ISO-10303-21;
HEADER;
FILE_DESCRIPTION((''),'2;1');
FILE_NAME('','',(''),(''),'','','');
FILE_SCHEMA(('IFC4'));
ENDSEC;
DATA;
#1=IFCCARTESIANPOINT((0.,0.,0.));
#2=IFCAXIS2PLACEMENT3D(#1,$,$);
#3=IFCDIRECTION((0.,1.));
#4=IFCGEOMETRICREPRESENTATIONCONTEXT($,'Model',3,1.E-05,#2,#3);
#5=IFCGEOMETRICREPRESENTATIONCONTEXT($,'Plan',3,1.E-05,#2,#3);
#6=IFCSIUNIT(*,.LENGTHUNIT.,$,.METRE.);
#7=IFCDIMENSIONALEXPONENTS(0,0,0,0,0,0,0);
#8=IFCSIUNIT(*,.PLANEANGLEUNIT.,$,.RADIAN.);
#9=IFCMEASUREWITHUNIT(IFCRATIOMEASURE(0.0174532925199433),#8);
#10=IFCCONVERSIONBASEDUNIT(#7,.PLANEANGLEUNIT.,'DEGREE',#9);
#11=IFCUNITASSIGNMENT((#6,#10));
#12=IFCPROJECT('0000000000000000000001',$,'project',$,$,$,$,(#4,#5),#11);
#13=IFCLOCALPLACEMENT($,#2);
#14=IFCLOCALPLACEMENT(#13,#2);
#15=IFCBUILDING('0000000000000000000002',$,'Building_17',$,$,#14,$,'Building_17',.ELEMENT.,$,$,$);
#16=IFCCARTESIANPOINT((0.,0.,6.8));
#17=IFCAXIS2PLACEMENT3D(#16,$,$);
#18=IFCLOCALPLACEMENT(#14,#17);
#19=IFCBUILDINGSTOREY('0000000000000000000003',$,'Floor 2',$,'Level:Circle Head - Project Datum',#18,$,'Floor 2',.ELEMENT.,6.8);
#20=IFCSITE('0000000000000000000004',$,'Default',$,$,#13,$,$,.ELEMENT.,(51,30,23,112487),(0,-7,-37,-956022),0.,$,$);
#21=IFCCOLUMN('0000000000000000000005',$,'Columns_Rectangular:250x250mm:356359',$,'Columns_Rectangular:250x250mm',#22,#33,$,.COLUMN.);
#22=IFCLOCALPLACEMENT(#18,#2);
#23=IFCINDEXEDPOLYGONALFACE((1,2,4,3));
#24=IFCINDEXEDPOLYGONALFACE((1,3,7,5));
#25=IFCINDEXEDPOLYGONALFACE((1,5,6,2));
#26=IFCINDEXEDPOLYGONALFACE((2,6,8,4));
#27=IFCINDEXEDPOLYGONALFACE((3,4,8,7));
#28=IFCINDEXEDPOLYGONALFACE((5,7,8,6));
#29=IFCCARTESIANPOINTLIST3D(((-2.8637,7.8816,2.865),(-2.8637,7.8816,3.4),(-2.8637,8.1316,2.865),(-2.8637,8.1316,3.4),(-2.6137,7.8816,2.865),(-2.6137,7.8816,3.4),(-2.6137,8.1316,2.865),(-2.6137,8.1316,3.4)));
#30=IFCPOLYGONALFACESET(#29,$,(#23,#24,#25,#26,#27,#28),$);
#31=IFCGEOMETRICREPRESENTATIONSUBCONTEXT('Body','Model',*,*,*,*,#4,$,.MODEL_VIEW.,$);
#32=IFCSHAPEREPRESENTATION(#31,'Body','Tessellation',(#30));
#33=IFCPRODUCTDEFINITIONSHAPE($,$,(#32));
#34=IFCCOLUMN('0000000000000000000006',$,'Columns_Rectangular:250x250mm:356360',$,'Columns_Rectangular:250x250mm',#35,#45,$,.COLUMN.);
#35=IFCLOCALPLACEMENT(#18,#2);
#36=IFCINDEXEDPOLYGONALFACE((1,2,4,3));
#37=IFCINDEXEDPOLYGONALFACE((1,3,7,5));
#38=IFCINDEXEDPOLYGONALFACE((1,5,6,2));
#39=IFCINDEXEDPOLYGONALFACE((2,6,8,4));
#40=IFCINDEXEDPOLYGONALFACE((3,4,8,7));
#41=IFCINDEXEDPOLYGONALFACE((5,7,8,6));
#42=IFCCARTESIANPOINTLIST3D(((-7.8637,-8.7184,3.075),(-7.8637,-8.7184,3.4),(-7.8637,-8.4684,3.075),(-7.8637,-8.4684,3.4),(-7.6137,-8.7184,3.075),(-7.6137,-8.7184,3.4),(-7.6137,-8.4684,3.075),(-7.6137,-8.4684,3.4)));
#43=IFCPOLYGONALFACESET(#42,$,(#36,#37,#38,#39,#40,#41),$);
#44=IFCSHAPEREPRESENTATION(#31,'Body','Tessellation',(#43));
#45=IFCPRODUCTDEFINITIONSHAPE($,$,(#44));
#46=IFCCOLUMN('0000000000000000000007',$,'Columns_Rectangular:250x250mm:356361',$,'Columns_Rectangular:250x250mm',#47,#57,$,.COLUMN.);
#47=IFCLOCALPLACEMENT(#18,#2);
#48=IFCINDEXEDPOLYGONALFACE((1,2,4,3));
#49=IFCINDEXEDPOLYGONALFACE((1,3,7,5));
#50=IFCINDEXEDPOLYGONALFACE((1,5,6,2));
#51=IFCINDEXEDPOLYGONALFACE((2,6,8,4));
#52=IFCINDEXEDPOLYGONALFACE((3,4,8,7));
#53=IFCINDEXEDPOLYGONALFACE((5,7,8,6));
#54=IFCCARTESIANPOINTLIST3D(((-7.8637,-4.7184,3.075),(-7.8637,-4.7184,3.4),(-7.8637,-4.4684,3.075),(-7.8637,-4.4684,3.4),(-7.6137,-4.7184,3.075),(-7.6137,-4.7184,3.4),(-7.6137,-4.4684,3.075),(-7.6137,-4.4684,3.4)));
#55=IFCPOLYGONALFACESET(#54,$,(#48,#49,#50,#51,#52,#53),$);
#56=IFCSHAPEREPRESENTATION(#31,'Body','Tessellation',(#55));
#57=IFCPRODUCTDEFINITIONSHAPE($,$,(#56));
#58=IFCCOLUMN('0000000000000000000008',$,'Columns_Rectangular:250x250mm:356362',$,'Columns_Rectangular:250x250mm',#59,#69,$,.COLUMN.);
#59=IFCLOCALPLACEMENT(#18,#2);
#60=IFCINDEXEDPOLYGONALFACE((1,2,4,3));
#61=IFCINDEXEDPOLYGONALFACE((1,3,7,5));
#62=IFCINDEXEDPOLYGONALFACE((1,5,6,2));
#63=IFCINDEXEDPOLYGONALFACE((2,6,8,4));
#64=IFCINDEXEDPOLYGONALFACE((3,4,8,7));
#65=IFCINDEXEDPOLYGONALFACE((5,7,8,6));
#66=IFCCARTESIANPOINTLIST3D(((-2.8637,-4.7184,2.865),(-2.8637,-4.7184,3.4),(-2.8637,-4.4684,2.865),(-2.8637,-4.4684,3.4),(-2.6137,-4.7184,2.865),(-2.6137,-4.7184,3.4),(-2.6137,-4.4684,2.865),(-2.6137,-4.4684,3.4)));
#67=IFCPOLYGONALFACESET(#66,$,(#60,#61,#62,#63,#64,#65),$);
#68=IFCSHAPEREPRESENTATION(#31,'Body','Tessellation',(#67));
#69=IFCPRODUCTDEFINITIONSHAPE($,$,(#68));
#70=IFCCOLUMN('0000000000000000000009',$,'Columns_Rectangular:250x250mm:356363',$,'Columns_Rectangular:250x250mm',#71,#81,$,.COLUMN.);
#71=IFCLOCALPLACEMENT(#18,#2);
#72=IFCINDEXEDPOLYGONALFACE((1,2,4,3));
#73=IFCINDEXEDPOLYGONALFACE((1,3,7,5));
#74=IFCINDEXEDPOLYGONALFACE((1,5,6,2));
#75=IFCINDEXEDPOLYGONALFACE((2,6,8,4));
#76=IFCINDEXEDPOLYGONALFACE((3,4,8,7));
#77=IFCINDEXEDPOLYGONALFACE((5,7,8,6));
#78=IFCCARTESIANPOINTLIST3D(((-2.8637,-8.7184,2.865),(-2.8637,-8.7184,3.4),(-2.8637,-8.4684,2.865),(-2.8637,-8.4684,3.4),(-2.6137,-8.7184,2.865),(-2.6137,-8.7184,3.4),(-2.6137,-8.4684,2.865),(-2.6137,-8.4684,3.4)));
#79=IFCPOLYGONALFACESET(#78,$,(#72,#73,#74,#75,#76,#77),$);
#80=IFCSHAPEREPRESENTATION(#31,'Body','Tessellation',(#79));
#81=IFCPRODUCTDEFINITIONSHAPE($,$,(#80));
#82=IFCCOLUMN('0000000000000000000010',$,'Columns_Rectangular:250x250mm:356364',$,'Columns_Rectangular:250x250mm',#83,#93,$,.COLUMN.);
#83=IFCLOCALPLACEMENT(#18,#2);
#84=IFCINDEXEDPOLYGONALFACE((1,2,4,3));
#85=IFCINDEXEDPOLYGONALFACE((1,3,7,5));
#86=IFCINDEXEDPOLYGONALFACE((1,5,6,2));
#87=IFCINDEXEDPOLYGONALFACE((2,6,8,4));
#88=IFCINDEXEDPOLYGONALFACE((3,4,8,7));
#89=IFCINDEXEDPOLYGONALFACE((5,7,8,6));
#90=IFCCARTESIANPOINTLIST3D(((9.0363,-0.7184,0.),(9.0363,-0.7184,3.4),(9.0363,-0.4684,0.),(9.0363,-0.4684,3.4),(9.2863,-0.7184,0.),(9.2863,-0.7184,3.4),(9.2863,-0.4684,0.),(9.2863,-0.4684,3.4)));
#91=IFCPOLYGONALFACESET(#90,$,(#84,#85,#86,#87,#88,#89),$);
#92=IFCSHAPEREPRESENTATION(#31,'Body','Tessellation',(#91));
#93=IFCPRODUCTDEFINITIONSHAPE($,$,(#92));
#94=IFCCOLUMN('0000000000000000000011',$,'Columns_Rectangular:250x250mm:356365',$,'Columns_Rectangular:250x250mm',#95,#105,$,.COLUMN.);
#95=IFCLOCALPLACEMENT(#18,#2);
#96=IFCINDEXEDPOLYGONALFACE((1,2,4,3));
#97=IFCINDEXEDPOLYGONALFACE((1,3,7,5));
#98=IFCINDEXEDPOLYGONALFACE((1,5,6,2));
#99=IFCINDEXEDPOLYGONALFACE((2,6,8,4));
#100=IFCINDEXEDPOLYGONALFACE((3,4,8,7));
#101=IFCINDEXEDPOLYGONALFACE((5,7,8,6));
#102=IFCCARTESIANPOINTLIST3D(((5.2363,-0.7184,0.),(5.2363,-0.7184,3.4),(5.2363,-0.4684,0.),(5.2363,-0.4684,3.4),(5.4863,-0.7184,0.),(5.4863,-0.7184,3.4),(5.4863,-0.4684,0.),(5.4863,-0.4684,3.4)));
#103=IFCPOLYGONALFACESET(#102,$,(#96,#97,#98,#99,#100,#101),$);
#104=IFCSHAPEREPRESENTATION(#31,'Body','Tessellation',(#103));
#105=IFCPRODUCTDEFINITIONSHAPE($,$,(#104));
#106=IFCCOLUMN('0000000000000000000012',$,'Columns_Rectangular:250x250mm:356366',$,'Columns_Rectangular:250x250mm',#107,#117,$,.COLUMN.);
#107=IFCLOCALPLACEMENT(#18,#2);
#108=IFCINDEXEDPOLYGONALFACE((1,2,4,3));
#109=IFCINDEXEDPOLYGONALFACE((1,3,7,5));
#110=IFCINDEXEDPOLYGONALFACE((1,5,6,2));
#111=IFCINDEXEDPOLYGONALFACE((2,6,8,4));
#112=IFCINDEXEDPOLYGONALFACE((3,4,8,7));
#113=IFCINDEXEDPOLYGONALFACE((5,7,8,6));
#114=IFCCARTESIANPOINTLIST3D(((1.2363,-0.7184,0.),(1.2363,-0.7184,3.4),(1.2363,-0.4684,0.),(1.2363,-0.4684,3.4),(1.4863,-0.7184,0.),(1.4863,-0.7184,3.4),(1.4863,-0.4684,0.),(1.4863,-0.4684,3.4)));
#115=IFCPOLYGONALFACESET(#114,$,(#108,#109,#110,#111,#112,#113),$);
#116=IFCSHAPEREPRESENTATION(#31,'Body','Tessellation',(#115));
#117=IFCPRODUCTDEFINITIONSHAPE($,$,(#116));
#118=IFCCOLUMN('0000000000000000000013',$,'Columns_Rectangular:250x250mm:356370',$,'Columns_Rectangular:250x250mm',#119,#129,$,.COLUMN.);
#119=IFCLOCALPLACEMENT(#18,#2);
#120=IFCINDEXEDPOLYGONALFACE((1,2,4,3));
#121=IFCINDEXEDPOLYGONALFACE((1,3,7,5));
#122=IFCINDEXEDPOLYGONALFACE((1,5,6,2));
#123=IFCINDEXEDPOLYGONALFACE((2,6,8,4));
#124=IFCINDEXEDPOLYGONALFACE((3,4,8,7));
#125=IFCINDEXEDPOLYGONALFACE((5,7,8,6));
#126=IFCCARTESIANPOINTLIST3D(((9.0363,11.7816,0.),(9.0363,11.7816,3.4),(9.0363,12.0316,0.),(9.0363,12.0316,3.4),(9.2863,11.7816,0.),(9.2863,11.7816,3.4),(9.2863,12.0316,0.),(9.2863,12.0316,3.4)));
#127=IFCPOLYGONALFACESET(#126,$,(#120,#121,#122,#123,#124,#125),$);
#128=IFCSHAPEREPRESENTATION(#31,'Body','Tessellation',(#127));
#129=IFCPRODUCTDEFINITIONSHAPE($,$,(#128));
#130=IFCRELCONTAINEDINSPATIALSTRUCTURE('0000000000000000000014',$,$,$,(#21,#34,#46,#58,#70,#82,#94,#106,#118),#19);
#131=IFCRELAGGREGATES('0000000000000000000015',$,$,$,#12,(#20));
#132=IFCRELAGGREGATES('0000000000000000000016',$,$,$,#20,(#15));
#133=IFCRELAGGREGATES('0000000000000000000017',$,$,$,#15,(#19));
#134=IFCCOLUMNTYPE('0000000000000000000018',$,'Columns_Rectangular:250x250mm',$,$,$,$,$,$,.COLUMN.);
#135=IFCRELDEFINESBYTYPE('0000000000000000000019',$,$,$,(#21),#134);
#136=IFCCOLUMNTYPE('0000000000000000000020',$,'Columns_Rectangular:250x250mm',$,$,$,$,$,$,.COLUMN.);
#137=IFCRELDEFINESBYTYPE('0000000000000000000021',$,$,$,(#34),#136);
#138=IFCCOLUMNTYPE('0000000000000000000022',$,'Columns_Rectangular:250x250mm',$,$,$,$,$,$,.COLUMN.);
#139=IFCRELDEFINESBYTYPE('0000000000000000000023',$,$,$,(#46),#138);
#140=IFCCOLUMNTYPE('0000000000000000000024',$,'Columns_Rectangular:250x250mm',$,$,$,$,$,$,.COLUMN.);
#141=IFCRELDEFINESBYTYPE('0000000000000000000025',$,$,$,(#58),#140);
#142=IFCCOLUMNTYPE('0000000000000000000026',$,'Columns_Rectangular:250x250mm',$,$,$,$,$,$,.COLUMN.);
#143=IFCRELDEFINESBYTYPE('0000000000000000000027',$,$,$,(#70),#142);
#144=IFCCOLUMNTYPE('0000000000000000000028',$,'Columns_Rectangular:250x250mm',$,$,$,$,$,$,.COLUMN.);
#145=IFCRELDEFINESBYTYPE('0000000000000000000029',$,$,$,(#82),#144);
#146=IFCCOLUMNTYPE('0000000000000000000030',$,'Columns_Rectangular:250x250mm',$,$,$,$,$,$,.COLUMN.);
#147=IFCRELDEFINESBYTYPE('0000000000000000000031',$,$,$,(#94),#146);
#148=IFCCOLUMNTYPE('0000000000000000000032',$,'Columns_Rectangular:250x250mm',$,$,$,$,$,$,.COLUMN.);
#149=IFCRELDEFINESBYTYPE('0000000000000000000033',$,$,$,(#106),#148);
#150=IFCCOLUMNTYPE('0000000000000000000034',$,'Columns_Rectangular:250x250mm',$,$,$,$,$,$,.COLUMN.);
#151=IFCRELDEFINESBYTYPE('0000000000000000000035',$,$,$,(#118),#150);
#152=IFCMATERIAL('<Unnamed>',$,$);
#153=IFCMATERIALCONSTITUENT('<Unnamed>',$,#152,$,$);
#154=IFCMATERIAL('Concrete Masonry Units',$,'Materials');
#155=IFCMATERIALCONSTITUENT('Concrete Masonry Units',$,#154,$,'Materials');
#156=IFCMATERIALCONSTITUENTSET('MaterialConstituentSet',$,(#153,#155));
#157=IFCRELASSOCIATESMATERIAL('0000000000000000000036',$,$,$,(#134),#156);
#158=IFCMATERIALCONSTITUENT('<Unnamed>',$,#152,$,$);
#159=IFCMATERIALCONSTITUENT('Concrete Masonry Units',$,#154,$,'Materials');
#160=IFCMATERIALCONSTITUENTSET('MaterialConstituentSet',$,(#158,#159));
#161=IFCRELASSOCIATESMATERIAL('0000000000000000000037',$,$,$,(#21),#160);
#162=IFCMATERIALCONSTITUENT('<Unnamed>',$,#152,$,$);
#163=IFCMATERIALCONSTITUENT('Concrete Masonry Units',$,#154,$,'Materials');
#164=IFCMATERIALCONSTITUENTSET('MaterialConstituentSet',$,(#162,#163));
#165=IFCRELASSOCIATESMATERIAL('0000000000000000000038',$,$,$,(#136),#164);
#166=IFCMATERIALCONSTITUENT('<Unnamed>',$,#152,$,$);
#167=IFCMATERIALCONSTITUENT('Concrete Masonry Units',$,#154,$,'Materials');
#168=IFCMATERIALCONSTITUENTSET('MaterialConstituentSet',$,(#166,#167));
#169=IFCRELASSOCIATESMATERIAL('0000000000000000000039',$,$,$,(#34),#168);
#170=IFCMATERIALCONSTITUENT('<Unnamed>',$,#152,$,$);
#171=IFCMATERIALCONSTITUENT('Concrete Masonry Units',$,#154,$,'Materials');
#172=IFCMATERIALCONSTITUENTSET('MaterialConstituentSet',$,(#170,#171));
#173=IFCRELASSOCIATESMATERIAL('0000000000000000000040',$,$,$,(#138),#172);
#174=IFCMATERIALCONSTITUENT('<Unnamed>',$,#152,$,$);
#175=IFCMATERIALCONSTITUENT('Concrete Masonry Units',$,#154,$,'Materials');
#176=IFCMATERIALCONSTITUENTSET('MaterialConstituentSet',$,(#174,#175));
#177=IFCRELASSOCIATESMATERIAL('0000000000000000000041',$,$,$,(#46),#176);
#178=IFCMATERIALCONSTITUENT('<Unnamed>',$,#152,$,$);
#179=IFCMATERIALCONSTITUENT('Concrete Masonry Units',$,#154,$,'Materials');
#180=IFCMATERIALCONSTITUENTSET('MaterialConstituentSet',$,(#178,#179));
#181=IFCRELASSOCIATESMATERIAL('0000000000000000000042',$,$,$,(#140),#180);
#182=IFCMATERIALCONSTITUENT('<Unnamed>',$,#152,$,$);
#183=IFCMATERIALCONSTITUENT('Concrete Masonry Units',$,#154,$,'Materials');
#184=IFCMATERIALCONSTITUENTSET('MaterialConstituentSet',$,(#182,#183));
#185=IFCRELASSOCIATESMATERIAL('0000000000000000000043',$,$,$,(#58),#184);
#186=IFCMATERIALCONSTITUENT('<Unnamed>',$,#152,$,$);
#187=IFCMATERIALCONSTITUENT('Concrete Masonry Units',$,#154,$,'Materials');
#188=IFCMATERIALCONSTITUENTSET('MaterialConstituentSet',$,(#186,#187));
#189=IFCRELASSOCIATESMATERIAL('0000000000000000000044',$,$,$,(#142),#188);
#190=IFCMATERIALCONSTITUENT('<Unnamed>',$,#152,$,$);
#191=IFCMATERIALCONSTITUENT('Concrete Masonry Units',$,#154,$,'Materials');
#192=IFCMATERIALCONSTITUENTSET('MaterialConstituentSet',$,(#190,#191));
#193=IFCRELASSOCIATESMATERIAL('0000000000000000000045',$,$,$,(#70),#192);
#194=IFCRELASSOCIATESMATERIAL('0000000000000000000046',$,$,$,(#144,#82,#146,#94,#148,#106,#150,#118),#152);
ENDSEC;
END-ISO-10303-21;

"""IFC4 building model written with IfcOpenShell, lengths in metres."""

from ifc_helpers import new_model, entity, si_unit, converted_unit, direction, frame, origin, place, context, subcontext, project, spatial, indexed_curve, outline, extrude, source, transform, mapped, material, constituent, constituent_set, type_object, type_shapes, element, save


model = new_model("IFC4")

# Units and contexts
model_context = context("Model", 3, precision=1e-05, world=origin(), true_north=direction((0.0, 1.0)))
plan_context = context("Plan", 3, precision=1e-05, world=origin(), true_north=direction((0.0, 1.0)))
body_context = subcontext(model_context, "Body", "Model", "MODEL_VIEW")
ifc_project = project(units=[si_unit("LENGTHUNIT", "METRE"), converted_unit("PLANEANGLEUNIT", "DEGREE", entity("IfcRatioMeasure", 0.0174532925199433), si_unit("PLANEANGLEUNIT", "RADIAN"), dimensions=[0, 0, 0, 0, 0, 0, 0])], contexts=[model_context, plan_context])

# Site, building, storey
site_placement = place(None, origin())
site = spatial("IfcSite", under=ifc_project, at=site_placement, Name="Default", CompositionType="ELEMENT", RefLatitude=(51, 30, 23, 112487), RefLongitude=(0, -7, -37, -956022), RefElevation=0.0)
building_placement = place(site_placement, origin())
building = spatial("IfcBuilding", under=site, at=building_placement, Name="Building_17", LongName="Building_17", CompositionType="ELEMENT")
storey_placement = place(building_placement, frame((0.0, 0.0, 6.8)))
storey = spatial("IfcBuildingStorey", under=building, at=storey_placement, Name="Floor 2", ObjectType="Level:Circle Head - Project Datum", LongName="Floor 2", CompositionType="ELEMENT", Elevation=6.8)

# Columns
ifc_material_1 = material(Name="<Unnamed>")
ifc_material_2 = material(Name="Concrete Masonry Units", Category="Materials")
ifc_constituent_1 = constituent(ifc_material_1, Name="<Unnamed>")
ifc_constituent_2 = constituent(ifc_material_2, Name="Concrete Masonry Units", Category="Materials")
ifc_constituent_set_1 = constituent_set(constituents=[ifc_constituent_1, ifc_constituent_2], Name="MaterialConstituentSet")
ifc_constituent_3 = constituent(ifc_material_1, Name="<Unnamed>")
ifc_constituent_4 = constituent(ifc_material_2, Name="Concrete Masonry Units", Category="Materials")
ifc_constituent_set_2 = constituent_set(constituents=[ifc_constituent_3, ifc_constituent_4], Name="MaterialConstituentSet")
column_type_1 = type_object("IfcColumnType", Name="Columns_Rectangular:250x250mm", PredefinedType="COLUMN", material=ifc_constituent_set_2)
shared_shape_1 = source(origin(), body_context, "Body", "SweptSolid", [
    extrude(outline(indexed_curve([(-0.125, -0.125), (0.125, -0.125), (0.125, 0.125), (-0.125, 0.125), (-0.125, -0.125)], self_intersect=False)), frame((-2.7387, 8.0066, 9.665), z_axis=(0.0, 0.0, 1.0), x_axis=(0.0, -1.0, 0.0)), (0.0, 0.0, 1.0), 0.535),
])
type_shapes(column_type_1, [shared_shape_1])
column_1_placement = place(storey_placement, frame((0.0, 0.0, -6.8)))
element("IfcColumn", 1, at=column_1_placement, inside=storey, type_object=column_type_1, material=ifc_constituent_set_1, Name="Columns_Rectangular:250x250mm:356359", ObjectType="Columns_Rectangular:250x250mm", PredefinedType="COLUMN", context=body_context, shape_type="MappedRepresentation", body=[
    mapped(shared_shape_1, transform((0.0, 0.0, 0.0), scale=1.0)),
])
ifc_constituent_5 = constituent(ifc_material_1, Name="<Unnamed>")
ifc_constituent_6 = constituent(ifc_material_2, Name="Concrete Masonry Units", Category="Materials")
ifc_constituent_set_3 = constituent_set(constituents=[ifc_constituent_5, ifc_constituent_6], Name="MaterialConstituentSet")
ifc_constituent_7 = constituent(ifc_material_1, Name="<Unnamed>")
ifc_constituent_8 = constituent(ifc_material_2, Name="Concrete Masonry Units", Category="Materials")
ifc_constituent_set_4 = constituent_set(constituents=[ifc_constituent_7, ifc_constituent_8], Name="MaterialConstituentSet")
column_type_2 = type_object("IfcColumnType", Name="Columns_Rectangular:250x250mm", PredefinedType="COLUMN", material=ifc_constituent_set_4)
shared_shape_2 = source(origin(), body_context, "Body", "SweptSolid", [
    extrude(outline(indexed_curve([(-0.125, -0.125), (0.125, -0.125), (0.125, 0.125), (-0.125, 0.125), (-0.125, -0.125)], self_intersect=False)), frame((-7.7387, -8.5934, 9.875), z_axis=(0.0, 0.0, 1.0), x_axis=(0.0, -1.0, 0.0)), (0.0, 0.0, 1.0), 0.325),
])
type_shapes(column_type_2, [shared_shape_2])
column_2_placement = place(storey_placement, frame((0.0, 0.0, -6.8)))
element("IfcColumn", 2, at=column_2_placement, inside=storey, type_object=column_type_2, material=ifc_constituent_set_3, Name="Columns_Rectangular:250x250mm:356360", ObjectType="Columns_Rectangular:250x250mm", PredefinedType="COLUMN", context=body_context, shape_type="MappedRepresentation", body=[
    mapped(shared_shape_2, transform((0.0, 0.0, 0.0), scale=1.0)),
])
ifc_constituent_9 = constituent(ifc_material_1, Name="<Unnamed>")
ifc_constituent_10 = constituent(ifc_material_2, Name="Concrete Masonry Units", Category="Materials")
ifc_constituent_set_5 = constituent_set(constituents=[ifc_constituent_9, ifc_constituent_10], Name="MaterialConstituentSet")
ifc_constituent_11 = constituent(ifc_material_1, Name="<Unnamed>")
ifc_constituent_12 = constituent(ifc_material_2, Name="Concrete Masonry Units", Category="Materials")
ifc_constituent_set_6 = constituent_set(constituents=[ifc_constituent_11, ifc_constituent_12], Name="MaterialConstituentSet")
column_type_3 = type_object("IfcColumnType", Name="Columns_Rectangular:250x250mm", PredefinedType="COLUMN", material=ifc_constituent_set_6)
shared_shape_3 = source(origin(), body_context, "Body", "SweptSolid", [
    extrude(outline(indexed_curve([(-0.125, -0.125), (0.125, -0.125), (0.125, 0.125), (-0.125, 0.125), (-0.125, -0.125)], self_intersect=False)), frame((-7.7387, -4.5934, 9.875), z_axis=(0.0, 0.0, 1.0), x_axis=(0.0, -1.0, 0.0)), (0.0, 0.0, 1.0), 0.325),
])
type_shapes(column_type_3, [shared_shape_3])
column_3_placement = place(storey_placement, frame((0.0, 0.0, -6.8)))
element("IfcColumn", 3, at=column_3_placement, inside=storey, type_object=column_type_3, material=ifc_constituent_set_5, Name="Columns_Rectangular:250x250mm:356361", ObjectType="Columns_Rectangular:250x250mm", PredefinedType="COLUMN", context=body_context, shape_type="MappedRepresentation", body=[
    mapped(shared_shape_3, transform((0.0, 0.0, 0.0), scale=1.0)),
])
ifc_constituent_13 = constituent(ifc_material_1, Name="<Unnamed>")
ifc_constituent_14 = constituent(ifc_material_2, Name="Concrete Masonry Units", Category="Materials")
ifc_constituent_set_7 = constituent_set(constituents=[ifc_constituent_13, ifc_constituent_14], Name="MaterialConstituentSet")
ifc_constituent_15 = constituent(ifc_material_1, Name="<Unnamed>")
ifc_constituent_16 = constituent(ifc_material_2, Name="Concrete Masonry Units", Category="Materials")
ifc_constituent_set_8 = constituent_set(constituents=[ifc_constituent_15, ifc_constituent_16], Name="MaterialConstituentSet")
column_type_4 = type_object("IfcColumnType", Name="Columns_Rectangular:250x250mm", PredefinedType="COLUMN", material=ifc_constituent_set_8)
shared_shape_4 = source(origin(), body_context, "Body", "SweptSolid", [
    extrude(outline(indexed_curve([(-0.125, -0.125), (0.125, -0.125), (0.125, 0.125), (-0.125, 0.125), (-0.125, -0.125)], self_intersect=False)), frame((-2.7387, -4.5934, 9.665), z_axis=(0.0, 0.0, 1.0), x_axis=(0.0, -1.0, 0.0)), (0.0, 0.0, 1.0), 0.535),
])
type_shapes(column_type_4, [shared_shape_4])
column_4_placement = place(storey_placement, frame((0.0, 0.0, -6.8)))
element("IfcColumn", 4, at=column_4_placement, inside=storey, type_object=column_type_4, material=ifc_constituent_set_7, Name="Columns_Rectangular:250x250mm:356362", ObjectType="Columns_Rectangular:250x250mm", PredefinedType="COLUMN", context=body_context, shape_type="MappedRepresentation", body=[
    mapped(shared_shape_4, transform((0.0, 0.0, 0.0), scale=1.0)),
])
ifc_constituent_17 = constituent(ifc_material_1, Name="<Unnamed>")
ifc_constituent_18 = constituent(ifc_material_2, Name="Concrete Masonry Units", Category="Materials")
ifc_constituent_set_9 = constituent_set(constituents=[ifc_constituent_17, ifc_constituent_18], Name="MaterialConstituentSet")
ifc_constituent_19 = constituent(ifc_material_1, Name="<Unnamed>")
ifc_constituent_20 = constituent(ifc_material_2, Name="Concrete Masonry Units", Category="Materials")
ifc_constituent_set_10 = constituent_set(constituents=[ifc_constituent_19, ifc_constituent_20], Name="MaterialConstituentSet")
column_type_5 = type_object("IfcColumnType", Name="Columns_Rectangular:250x250mm", PredefinedType="COLUMN", material=ifc_constituent_set_10)
shared_shape_5 = source(origin(), body_context, "Body", "SweptSolid", [
    extrude(outline(indexed_curve([(-0.125, -0.125), (0.125, -0.125), (0.125, 0.125), (-0.125, 0.125), (-0.125, -0.125)], self_intersect=False)), frame((-2.7387, -8.5934, 9.665), z_axis=(0.0, 0.0, 1.0), x_axis=(0.0, -1.0, 0.0)), (0.0, 0.0, 1.0), 0.535),
])
type_shapes(column_type_5, [shared_shape_5])
column_5_placement = place(storey_placement, frame((0.0, 0.0, -6.8)))
element("IfcColumn", 5, at=column_5_placement, inside=storey, type_object=column_type_5, material=ifc_constituent_set_9, Name="Columns_Rectangular:250x250mm:356363", ObjectType="Columns_Rectangular:250x250mm", PredefinedType="COLUMN", context=body_context, shape_type="MappedRepresentation", body=[
    mapped(shared_shape_5, transform((0.0, 0.0, 0.0), scale=1.0)),
])
column_type_6 = type_object("IfcColumnType", Name="Columns_Rectangular:250x250mm", PredefinedType="COLUMN", material=ifc_material_1)
shared_shape_6 = source(origin(), body_context, "Body", "SweptSolid", [
    extrude(outline(indexed_curve([(-0.125, -0.125), (0.125, -0.125), (0.125, 0.125), (-0.125, 0.125), (-0.125, -0.125)], self_intersect=False)), frame((9.1613, -0.5934, 6.8), z_axis=(0.0, 0.0, 1.0), x_axis=(0.0, -1.0, 0.0)), (0.0, 0.0, 1.0), 3.4),
])
type_shapes(column_type_6, [shared_shape_6])
column_6_placement = place(storey_placement, frame((0.0, 0.0, -6.8)))
element("IfcColumn", 6, at=column_6_placement, inside=storey, type_object=column_type_6, material=ifc_material_1, Name="Columns_Rectangular:250x250mm:356364", ObjectType="Columns_Rectangular:250x250mm", PredefinedType="COLUMN", context=body_context, shape_type="MappedRepresentation", body=[
    mapped(shared_shape_6, transform((0.0, 0.0, 0.0), scale=1.0)),
])
column_type_7 = type_object("IfcColumnType", Name="Columns_Rectangular:250x250mm", PredefinedType="COLUMN", material=ifc_material_1)
shared_shape_7 = source(origin(), body_context, "Body", "SweptSolid", [
    extrude(outline(indexed_curve([(-0.125, -0.125), (0.125, -0.125), (0.125, 0.125), (-0.125, 0.125), (-0.125, -0.125)], self_intersect=False)), frame((5.3613, -0.5934, 6.8), z_axis=(0.0, 0.0, 1.0), x_axis=(0.0, -1.0, 0.0)), (0.0, 0.0, 1.0), 3.4),
])
type_shapes(column_type_7, [shared_shape_7])
column_7_placement = place(storey_placement, frame((0.0, 0.0, -6.8)))
element("IfcColumn", 7, at=column_7_placement, inside=storey, type_object=column_type_7, material=ifc_material_1, Name="Columns_Rectangular:250x250mm:356365", ObjectType="Columns_Rectangular:250x250mm", PredefinedType="COLUMN", context=body_context, shape_type="MappedRepresentation", body=[
    mapped(shared_shape_7, transform((0.0, 0.0, 0.0), scale=1.0)),
])
column_type_8 = type_object("IfcColumnType", Name="Columns_Rectangular:250x250mm", PredefinedType="COLUMN", material=ifc_material_1)
shared_shape_8 = source(origin(), body_context, "Body", "SweptSolid", [
    extrude(outline(indexed_curve([(-0.125, -0.125), (0.125, -0.125), (0.125, 0.125), (-0.125, 0.125), (-0.125, -0.125)], self_intersect=False)), frame((1.3613, -0.5934, 6.8), z_axis=(0.0, 0.0, 1.0), x_axis=(0.0, -1.0, 0.0)), (0.0, 0.0, 1.0), 3.4),
])
type_shapes(column_type_8, [shared_shape_8])
column_8_placement = place(storey_placement, frame((0.0, 0.0, -6.8)))
element("IfcColumn", 8, at=column_8_placement, inside=storey, type_object=column_type_8, material=ifc_material_1, Name="Columns_Rectangular:250x250mm:356366", ObjectType="Columns_Rectangular:250x250mm", PredefinedType="COLUMN", context=body_context, shape_type="MappedRepresentation", body=[
    mapped(shared_shape_8, transform((0.0, 0.0, 0.0), scale=1.0)),
])
column_type_9 = type_object("IfcColumnType", Name="Columns_Rectangular:250x250mm", PredefinedType="COLUMN", material=ifc_material_1)
shared_shape_9 = source(origin(), body_context, "Body", "SweptSolid", [
    extrude(outline(indexed_curve([(-0.125, -0.125), (0.125, -0.125), (0.125, 0.125), (-0.125, 0.125), (-0.125, -0.125)], self_intersect=False)), frame((9.1613, 11.9066, 6.8), z_axis=(0.0, 0.0, 1.0), x_axis=(0.0, -1.0, 0.0)), (0.0, 0.0, 1.0), 3.4),
])
type_shapes(column_type_9, [shared_shape_9])
column_9_placement = place(storey_placement, frame((0.0, 0.0, -6.8)))
element("IfcColumn", 9, at=column_9_placement, inside=storey, type_object=column_type_9, material=ifc_material_1, Name="Columns_Rectangular:250x250mm:356370", ObjectType="Columns_Rectangular:250x250mm", PredefinedType="COLUMN", context=body_context, shape_type="MappedRepresentation", body=[
    mapped(shared_shape_9, transform((0.0, 0.0, 0.0), scale=1.0)),
])

save(model, "model.ifc")
